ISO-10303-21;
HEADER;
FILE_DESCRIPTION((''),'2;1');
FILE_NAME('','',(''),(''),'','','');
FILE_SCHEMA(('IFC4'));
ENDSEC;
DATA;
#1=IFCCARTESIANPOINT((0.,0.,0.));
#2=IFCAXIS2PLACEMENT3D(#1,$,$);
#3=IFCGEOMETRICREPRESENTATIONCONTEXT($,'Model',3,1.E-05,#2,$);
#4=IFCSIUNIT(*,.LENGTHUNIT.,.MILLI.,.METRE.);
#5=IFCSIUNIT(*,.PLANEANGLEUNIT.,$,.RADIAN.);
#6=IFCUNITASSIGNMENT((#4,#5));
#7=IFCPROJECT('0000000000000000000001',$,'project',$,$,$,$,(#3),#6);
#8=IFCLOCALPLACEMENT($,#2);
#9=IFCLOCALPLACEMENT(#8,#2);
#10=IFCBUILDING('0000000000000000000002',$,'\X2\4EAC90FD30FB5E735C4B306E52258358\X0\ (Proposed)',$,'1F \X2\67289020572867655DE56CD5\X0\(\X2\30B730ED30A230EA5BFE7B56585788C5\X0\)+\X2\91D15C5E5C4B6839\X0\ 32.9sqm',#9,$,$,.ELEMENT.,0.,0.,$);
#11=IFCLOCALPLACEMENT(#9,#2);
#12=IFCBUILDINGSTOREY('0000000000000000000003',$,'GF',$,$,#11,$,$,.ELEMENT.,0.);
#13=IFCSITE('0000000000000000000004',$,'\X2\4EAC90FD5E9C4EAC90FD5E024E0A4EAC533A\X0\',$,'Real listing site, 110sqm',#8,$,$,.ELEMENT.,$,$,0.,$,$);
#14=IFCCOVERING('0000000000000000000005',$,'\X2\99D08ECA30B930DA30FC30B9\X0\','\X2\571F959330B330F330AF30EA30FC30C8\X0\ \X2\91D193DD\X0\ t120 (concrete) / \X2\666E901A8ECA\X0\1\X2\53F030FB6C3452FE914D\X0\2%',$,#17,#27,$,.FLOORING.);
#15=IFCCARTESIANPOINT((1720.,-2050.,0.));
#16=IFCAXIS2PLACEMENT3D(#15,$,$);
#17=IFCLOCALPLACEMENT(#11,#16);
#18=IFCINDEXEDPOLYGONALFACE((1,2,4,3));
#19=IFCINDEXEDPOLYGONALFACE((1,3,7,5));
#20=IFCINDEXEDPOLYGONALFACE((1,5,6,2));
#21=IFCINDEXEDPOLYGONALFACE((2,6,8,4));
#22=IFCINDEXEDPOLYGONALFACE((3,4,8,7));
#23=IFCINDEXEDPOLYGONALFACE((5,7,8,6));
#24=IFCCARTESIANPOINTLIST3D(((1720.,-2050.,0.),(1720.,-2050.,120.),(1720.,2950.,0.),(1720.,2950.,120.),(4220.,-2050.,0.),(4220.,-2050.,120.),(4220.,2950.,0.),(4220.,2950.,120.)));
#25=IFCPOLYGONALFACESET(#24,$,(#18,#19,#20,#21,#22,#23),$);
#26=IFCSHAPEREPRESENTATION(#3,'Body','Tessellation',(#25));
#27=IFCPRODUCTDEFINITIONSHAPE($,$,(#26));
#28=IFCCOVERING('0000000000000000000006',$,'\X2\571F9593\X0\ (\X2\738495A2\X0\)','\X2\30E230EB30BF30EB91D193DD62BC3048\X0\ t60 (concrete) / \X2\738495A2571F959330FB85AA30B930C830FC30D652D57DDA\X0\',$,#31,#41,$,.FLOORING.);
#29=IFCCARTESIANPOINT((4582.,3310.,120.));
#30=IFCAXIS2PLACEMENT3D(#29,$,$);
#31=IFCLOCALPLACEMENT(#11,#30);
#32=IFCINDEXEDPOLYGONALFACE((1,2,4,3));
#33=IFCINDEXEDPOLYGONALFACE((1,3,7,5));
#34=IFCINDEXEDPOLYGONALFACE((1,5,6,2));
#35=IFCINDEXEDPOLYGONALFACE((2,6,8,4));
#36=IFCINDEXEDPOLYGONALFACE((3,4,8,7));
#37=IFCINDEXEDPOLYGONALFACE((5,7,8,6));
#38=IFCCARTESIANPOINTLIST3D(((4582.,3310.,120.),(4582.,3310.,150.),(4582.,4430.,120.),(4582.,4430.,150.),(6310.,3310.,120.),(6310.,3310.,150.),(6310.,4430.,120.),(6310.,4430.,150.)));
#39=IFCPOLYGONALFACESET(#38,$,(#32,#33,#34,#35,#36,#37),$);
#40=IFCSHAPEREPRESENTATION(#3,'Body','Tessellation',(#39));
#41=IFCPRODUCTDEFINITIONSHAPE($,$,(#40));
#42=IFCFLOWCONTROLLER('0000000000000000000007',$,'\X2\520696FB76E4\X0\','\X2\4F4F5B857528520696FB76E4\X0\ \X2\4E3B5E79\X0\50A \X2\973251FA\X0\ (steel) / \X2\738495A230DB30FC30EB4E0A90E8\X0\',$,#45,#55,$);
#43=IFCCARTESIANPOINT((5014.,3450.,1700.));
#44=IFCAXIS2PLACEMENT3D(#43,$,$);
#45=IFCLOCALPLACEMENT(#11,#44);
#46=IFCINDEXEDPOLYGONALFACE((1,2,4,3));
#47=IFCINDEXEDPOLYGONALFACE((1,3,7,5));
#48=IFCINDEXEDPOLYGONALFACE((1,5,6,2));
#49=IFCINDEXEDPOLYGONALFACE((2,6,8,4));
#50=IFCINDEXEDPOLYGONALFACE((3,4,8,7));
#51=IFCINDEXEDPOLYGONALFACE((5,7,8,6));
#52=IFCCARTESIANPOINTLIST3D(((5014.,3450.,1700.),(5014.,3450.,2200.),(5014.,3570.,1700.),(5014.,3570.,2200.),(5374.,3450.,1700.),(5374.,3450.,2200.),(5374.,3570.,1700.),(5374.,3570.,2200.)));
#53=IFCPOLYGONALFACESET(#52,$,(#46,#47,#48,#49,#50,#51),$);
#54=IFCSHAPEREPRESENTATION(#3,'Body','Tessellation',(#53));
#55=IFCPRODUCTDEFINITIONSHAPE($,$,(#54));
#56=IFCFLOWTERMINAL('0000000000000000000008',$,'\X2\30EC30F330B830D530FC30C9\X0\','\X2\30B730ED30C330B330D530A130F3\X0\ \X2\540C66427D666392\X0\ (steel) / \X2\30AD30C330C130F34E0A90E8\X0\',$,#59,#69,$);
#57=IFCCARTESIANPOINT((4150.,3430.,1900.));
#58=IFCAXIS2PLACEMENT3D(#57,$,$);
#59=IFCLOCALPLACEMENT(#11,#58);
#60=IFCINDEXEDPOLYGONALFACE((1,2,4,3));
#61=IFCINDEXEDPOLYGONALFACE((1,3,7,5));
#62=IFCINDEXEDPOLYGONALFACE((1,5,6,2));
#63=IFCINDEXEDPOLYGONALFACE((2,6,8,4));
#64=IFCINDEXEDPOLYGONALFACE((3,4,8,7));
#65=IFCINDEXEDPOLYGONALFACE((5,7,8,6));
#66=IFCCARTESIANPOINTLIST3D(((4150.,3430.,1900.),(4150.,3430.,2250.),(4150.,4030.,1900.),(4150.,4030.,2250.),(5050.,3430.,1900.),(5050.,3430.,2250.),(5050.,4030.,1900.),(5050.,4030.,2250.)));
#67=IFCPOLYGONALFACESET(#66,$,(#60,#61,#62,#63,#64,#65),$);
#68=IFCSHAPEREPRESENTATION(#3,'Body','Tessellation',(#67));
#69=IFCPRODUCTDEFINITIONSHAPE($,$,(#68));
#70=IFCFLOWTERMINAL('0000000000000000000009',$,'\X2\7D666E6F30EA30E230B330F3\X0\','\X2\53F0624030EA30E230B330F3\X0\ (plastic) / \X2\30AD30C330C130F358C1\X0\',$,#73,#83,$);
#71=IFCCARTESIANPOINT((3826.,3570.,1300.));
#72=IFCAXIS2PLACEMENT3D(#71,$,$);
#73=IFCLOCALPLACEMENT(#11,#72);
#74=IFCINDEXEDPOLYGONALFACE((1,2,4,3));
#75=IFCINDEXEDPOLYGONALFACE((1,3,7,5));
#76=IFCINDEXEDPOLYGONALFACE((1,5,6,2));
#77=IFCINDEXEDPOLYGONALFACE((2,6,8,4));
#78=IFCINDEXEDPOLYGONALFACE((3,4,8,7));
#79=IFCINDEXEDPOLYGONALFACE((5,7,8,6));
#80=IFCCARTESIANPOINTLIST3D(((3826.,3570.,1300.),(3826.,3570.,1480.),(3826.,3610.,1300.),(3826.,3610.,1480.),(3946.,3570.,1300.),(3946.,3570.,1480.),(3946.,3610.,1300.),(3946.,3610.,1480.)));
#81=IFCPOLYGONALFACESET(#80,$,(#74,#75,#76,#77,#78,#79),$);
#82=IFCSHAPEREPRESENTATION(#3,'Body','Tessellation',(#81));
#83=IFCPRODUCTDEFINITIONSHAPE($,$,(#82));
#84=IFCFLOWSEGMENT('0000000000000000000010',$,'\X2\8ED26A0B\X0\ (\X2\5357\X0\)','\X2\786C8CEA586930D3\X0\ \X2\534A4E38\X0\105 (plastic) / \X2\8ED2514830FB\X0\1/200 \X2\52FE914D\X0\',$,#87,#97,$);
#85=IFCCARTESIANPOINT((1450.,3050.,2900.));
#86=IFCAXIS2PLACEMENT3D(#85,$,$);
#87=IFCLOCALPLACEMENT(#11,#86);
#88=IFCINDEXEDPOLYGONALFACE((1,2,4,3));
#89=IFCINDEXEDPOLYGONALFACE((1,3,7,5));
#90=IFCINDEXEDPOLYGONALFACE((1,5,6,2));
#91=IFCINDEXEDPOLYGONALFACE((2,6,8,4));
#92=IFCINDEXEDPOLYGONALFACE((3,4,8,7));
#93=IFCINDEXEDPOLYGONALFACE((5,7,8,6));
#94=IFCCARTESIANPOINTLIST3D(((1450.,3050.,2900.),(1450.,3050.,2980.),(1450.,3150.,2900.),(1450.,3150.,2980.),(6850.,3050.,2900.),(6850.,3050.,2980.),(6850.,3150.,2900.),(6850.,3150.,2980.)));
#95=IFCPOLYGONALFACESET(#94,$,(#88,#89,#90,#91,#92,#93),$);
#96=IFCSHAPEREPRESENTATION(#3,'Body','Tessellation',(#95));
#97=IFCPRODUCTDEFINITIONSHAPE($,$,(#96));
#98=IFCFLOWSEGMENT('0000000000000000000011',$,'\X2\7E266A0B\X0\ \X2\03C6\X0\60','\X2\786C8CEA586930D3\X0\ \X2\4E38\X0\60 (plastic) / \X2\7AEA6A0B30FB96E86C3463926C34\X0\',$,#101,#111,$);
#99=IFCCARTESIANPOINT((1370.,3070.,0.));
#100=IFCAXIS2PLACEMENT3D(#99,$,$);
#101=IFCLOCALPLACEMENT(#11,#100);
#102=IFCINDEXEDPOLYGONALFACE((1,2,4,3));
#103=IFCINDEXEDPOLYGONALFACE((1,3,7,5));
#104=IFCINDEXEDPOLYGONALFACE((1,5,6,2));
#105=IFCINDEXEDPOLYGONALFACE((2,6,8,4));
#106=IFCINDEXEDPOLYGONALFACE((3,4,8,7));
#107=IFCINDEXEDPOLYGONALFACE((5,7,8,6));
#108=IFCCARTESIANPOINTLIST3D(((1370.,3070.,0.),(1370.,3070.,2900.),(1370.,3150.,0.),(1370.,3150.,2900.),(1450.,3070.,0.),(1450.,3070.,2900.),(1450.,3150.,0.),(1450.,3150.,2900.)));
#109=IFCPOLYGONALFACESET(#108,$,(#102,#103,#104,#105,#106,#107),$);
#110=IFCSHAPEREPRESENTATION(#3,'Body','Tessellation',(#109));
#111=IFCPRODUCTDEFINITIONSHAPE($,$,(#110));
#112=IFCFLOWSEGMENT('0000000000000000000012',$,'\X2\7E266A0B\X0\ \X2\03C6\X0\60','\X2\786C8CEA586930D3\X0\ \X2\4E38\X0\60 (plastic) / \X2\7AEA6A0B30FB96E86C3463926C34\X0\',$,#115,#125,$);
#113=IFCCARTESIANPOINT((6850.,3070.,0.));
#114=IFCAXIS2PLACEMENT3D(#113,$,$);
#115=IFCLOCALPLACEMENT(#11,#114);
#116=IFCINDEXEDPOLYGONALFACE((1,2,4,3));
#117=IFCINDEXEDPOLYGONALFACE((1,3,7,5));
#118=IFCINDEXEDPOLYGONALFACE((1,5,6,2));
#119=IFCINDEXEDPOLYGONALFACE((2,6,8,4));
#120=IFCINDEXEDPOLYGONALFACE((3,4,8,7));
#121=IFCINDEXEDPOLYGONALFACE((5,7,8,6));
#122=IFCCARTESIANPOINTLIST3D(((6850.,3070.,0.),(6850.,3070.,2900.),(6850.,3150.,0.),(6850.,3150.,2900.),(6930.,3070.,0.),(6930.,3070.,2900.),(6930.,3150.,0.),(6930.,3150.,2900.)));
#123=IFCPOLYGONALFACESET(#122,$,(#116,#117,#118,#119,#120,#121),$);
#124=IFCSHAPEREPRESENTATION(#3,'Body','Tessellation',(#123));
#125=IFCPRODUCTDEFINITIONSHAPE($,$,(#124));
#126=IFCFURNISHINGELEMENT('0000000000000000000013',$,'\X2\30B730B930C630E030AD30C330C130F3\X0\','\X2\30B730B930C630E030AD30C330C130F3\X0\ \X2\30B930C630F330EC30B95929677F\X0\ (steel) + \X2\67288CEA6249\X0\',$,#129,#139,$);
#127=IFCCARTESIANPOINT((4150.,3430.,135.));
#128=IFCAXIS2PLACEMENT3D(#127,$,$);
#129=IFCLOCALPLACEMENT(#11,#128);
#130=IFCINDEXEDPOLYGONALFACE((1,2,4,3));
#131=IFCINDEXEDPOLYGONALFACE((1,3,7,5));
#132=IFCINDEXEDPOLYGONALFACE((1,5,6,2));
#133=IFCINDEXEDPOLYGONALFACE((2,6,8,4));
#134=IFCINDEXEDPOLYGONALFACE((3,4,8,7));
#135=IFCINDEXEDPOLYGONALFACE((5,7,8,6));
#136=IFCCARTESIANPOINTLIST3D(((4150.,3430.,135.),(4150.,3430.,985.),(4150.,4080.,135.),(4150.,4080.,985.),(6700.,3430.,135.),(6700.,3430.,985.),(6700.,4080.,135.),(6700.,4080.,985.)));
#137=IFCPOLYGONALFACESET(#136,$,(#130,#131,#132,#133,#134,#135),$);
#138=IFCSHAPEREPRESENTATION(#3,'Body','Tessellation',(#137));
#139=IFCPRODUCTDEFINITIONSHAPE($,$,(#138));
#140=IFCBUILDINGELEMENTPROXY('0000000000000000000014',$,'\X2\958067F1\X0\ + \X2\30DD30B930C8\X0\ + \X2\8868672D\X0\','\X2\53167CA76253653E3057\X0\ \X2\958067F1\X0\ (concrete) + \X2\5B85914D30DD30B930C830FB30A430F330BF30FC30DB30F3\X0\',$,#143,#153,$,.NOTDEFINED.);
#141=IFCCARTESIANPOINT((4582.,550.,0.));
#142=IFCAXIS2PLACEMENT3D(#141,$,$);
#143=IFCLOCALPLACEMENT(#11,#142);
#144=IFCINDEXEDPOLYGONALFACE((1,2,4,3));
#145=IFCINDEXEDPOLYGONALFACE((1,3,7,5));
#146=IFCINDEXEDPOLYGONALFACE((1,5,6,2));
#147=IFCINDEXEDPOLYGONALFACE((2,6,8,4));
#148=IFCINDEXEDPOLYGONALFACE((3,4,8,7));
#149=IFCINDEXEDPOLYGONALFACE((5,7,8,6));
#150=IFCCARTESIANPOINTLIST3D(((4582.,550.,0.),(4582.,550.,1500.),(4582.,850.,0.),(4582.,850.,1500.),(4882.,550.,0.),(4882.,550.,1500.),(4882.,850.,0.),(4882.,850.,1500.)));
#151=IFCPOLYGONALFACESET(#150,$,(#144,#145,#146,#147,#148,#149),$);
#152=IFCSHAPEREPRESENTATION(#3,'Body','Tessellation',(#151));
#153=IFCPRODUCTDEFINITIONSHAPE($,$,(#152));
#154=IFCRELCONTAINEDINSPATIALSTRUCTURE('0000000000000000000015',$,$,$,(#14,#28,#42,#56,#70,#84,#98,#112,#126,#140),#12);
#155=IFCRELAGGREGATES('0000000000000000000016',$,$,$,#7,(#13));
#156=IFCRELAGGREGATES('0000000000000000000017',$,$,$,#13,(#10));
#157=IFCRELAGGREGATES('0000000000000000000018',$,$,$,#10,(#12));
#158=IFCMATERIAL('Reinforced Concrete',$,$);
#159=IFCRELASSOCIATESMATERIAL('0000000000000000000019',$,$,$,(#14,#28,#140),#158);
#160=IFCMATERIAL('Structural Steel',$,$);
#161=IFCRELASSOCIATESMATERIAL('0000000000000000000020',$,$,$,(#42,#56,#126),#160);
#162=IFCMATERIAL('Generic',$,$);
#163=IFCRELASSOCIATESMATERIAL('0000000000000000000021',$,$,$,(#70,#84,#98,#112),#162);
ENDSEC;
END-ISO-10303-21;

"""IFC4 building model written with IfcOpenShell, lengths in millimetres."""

from ifc_helpers import new_model, si_unit, frame, frame_2d, origin, place, context, project, spatial, rectangle, extrude, material, element, save


model = new_model("IFC4")

# Units and contexts
model_context = context("Model", 3, precision=1e-05, world=origin())
ifc_project = project(units=[si_unit("LENGTHUNIT", "METRE", prefix="MILLI"), si_unit("PLANEANGLEUNIT", "RADIAN")], contexts=[model_context])

# Site, building, storey
site_placement = place(None, origin())
site = spatial("IfcSite", under=ifc_project, at=site_placement, Name="京都府京都市上京区", ObjectType="Real listing site, 110sqm", CompositionType="ELEMENT", RefElevation=0.0)
building_placement = place(site_placement, origin())
building = spatial("IfcBuilding", under=site, at=building_placement, Name="京都・平屋の別荘 (Proposed)", ObjectType="1F 木造在来工法(シロアリ対策塗装)+金属屋根 32.9sqm", CompositionType="ELEMENT", ElevationOfRefHeight=0.0, ElevationOfTerrain=0.0)
storey_placement = place(building_placement, origin())
storey = spatial("IfcBuildingStorey", under=building, at=storey_placement, Name="GF", CompositionType="ELEMENT", Elevation=0.0)

# Shared definitions
ifc_material_1 = material(Name="Reinforced Concrete")

# Shared definitions
ifc_material_2 = material(Name="Structural Steel")

# Coverings
ifc_material_3 = material(Name="Generic")
covering_1_placement = place(storey_placement, frame((1720.0, -2050.0, 0.0)))
element("IfcCovering", 1, at=covering_1_placement, inside=storey, material=ifc_material_1, Name="駐車スペース", Description="土間コンクリート 金鏝 t120 (concrete) / 普通車1台・水勾配2%", PredefinedType="FLOORING", context=model_context, shape_type="SweptSolid", body=[
    extrude(rectangle(XDim=2500.0, YDim=5000.0, at=frame_2d((1250.0, 2500.0))), frame((1720.0, -2050.0, 0.0)), (0.0, 0.0, 1.0), 120.0),
])
covering_2_placement = place(storey_placement, frame((4582.0, 3310.0, 120.0)))
element("IfcCovering", 2, at=covering_2_placement, inside=storey, material=ifc_material_1, Name="土間 (玄関)", Description="モルタル金鏝押え t60 (concrete) / 玄関土間・薪ストーブ動線", PredefinedType="FLOORING", context=model_context, shape_type="SweptSolid", body=[
    extrude(rectangle(XDim=1728.0, YDim=1120.0, at=frame_2d((864.0, 560.0))), frame((4582.0, 3310.0, 120.0)), (0.0, 0.0, 1.0), 30.0),
])

# Flow controller
flow_controller_placement = place(storey_placement, frame((5014.0, 3450.0, 1700.0)))
element("IfcFlowController", 3, at=flow_controller_placement, inside=storey, material=ifc_material_2, Name="分電盤", Description="住宅用分電盤 主幹50A 露出 (steel) / 玄関ホール上部", context=model_context, shape_type="SweptSolid", body=[
    extrude(rectangle(XDim=360.0, YDim=120.0, at=frame_2d((180.0, 60.0))), frame((5014.0, 3450.0, 1700.0)), (0.0, 0.0, 1.0), 500.0),
])

# Flow terminals
flow_terminal_1_placement = place(storey_placement, frame((4150.0, 3430.0, 1900.0)))
element("IfcFlowTerminal", 4, at=flow_terminal_1_placement, inside=storey, material=ifc_material_2, Name="レンジフード", Description="シロッコファン 同時給排 (steel) / キッチン上部", context=model_context, shape_type="SweptSolid", body=[
    extrude(rectangle(XDim=900.0, YDim=600.0, at=frame_2d((450.0, 300.0))), frame((4150.0, 3430.0, 1900.0)), (0.0, 0.0, 1.0), 350.0),
])
flow_terminal_2_placement = place(storey_placement, frame((3826.0, 3570.0, 1300.0)))
element("IfcFlowTerminal", 5, at=flow_terminal_2_placement, inside=storey, material=ifc_material_3, Name="給湯リモコン", Description="台所リモコン (plastic) / キッチン壁", context=model_context, shape_type="SweptSolid", body=[
    extrude(rectangle(XDim=120.0, YDim=40.0, at=frame_2d((60.0, 20.0))), frame((3826.0, 3570.0, 1300.0)), (0.0, 0.0, 1.0), 180.0),
])

# Flow segments
flow_segment_1_placement = place(storey_placement, frame((1450.0, 3050.0, 2900.0)))
element("IfcFlowSegment", 6, at=flow_segment_1_placement, inside=storey, material=ifc_material_3, Name="軒樋 (南)", Description="硬質塩ビ 半丸105 (plastic) / 軒先・1/200 勾配", context=model_context, shape_type="SweptSolid", body=[
    extrude(rectangle(XDim=5400.0, YDim=100.0, at=frame_2d((2700.0, 50.0))), frame((1450.0, 3050.0, 2900.0)), (0.0, 0.0, 1.0), 80.0),
])
flow_segment_2_placement = place(storey_placement, frame((1370.0, 3070.0, 0.0)))
element("IfcFlowSegment", 7, at=flow_segment_2_placement, inside=storey, material=ifc_material_3, Name="縦樋 φ60", Description="硬質塩ビ 丸60 (plastic) / 竪樋・雨水排水", context=model_context, shape_type="SweptSolid", body=[
    extrude(rectangle(XDim=80.0, YDim=80.0, at=frame_2d((40.0, 40.0))), frame((1370.0, 3070.0, 0.0)), (0.0, 0.0, 1.0), 2900.0),
])
flow_segment_3_placement = place(storey_placement, frame((6850.0, 3070.0, 0.0)))
element("IfcFlowSegment", 8, at=flow_segment_3_placement, inside=storey, material=ifc_material_3, Name="縦樋 φ60", Description="硬質塩ビ 丸60 (plastic) / 竪樋・雨水排水", context=model_context, shape_type="SweptSolid", body=[
    extrude(rectangle(XDim=80.0, YDim=80.0, at=frame_2d((40.0, 40.0))), frame((6850.0, 3070.0, 0.0)), (0.0, 0.0, 1.0), 2900.0),
])

# Furnishing element
furnishing_placement = place(storey_placement, frame((4150.0, 3430.0, 135.0)))
element("IfcFurnishingElement", 9, at=furnishing_placement, inside=storey, material=ifc_material_2, Name="システムキッチン", Description="システムキッチン ステンレス天板 (steel) + 木質扉", context=model_context, shape_type="SweptSolid", body=[
    extrude(rectangle(XDim=2550.0, YDim=650.0, at=frame_2d((1275.0, 325.0))), frame((4150.0, 3430.0, 135.0)), (0.0, 0.0, 1.0), 850.0),
])

# Building element proxy
proxy_placement = place(storey_placement, frame((4582.0, 550.0, 0.0)))
element("IfcBuildingElementProxy", 10, at=proxy_placement, inside=storey, material=ifc_material_1, Name="門柱 + ポスト + 表札", Description="化粧打放し 門柱 (concrete) + 宅配ポスト・インターホン", PredefinedType="NOTDEFINED", context=model_context, shape_type="SweptSolid", body=[
    extrude(rectangle(XDim=300.0, YDim=300.0, at=frame_2d((150.0, 150.0))), frame((4582.0, 550.0, 0.0)), (0.0, 0.0, 1.0), 1500.0),
])

save(model, "model.ifc")
